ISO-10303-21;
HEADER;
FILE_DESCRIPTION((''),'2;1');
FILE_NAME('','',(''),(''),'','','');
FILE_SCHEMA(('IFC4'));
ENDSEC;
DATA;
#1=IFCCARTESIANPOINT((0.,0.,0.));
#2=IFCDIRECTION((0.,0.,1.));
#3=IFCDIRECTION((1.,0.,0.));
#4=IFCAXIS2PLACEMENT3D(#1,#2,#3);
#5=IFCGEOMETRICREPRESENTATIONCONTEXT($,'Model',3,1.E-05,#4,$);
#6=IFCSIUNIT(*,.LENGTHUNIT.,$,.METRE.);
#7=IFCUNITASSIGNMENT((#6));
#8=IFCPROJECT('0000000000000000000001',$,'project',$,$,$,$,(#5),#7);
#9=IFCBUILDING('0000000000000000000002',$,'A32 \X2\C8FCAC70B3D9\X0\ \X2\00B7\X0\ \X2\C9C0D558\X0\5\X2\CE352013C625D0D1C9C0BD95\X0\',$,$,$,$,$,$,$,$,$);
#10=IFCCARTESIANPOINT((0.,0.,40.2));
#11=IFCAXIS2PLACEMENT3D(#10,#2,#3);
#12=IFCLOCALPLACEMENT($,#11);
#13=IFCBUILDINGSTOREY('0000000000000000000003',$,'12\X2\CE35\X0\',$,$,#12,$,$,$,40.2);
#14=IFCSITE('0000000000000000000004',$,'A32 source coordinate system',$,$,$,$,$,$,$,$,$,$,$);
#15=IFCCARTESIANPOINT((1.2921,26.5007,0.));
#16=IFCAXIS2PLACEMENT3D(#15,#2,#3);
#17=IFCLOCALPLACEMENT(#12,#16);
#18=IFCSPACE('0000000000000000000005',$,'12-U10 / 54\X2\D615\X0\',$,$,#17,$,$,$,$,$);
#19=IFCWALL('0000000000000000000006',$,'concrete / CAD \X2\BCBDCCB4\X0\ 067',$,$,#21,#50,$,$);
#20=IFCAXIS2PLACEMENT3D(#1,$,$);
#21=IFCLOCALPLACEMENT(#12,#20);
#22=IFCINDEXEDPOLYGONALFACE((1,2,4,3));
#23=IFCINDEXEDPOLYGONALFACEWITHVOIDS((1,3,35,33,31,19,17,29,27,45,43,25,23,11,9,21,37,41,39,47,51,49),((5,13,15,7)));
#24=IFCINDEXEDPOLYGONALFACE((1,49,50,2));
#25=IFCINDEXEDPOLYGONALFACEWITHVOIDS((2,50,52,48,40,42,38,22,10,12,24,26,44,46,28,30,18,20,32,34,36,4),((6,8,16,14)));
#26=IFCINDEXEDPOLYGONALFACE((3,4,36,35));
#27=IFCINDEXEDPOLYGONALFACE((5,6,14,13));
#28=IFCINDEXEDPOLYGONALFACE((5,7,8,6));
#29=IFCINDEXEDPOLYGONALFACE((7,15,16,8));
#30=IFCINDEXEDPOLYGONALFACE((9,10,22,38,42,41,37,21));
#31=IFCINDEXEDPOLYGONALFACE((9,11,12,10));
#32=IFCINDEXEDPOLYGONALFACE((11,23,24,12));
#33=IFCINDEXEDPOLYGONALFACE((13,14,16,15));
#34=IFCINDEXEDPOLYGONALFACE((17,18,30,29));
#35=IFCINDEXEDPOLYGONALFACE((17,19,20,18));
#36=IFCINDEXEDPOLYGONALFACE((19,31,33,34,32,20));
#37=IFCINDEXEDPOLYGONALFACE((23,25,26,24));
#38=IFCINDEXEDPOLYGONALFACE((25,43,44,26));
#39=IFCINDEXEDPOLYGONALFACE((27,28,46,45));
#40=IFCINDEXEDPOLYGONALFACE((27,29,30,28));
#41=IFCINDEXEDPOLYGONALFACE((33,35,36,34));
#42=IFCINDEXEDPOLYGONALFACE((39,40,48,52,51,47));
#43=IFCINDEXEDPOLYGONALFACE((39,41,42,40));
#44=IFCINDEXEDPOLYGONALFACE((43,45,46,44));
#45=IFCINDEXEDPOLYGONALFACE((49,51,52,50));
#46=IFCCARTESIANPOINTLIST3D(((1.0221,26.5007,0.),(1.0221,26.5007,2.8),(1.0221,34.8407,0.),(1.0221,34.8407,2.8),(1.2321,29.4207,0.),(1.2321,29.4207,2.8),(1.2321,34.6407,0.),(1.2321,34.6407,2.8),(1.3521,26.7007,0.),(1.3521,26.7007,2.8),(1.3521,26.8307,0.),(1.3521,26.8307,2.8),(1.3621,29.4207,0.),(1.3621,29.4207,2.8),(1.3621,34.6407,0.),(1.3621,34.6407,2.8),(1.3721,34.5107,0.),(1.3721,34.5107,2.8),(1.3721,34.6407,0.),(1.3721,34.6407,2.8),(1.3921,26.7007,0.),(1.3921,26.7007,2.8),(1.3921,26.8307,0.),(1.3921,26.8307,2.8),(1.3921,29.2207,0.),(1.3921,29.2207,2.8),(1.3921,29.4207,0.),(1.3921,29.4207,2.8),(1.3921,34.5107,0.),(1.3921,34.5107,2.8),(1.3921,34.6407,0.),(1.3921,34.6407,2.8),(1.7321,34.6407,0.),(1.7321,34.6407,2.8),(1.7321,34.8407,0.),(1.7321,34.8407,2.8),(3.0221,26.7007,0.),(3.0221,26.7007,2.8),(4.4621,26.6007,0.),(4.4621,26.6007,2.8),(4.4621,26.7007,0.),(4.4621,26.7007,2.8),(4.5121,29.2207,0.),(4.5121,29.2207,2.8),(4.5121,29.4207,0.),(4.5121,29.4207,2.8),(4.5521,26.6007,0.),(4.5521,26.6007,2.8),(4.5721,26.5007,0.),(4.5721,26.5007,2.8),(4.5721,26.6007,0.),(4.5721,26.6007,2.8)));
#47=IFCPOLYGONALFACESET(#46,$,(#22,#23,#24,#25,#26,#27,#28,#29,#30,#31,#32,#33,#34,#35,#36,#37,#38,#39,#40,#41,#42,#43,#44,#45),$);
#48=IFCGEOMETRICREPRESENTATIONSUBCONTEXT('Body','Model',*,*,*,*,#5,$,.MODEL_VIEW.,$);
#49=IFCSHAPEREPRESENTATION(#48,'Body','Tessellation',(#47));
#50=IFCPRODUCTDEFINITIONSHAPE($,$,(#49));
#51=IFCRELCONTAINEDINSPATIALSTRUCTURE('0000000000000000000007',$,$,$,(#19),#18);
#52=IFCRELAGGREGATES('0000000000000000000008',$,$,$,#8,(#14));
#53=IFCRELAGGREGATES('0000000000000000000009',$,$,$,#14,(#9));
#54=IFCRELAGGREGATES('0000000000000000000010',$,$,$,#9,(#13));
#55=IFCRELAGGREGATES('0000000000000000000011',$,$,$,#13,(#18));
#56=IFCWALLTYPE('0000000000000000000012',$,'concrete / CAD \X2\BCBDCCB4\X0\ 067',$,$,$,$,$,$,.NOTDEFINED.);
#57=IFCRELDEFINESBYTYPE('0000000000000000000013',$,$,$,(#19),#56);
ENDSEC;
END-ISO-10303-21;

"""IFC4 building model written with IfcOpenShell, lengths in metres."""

from ifc_helpers import new_model, si_unit, frame, origin, origin_with_axes, place, context, subcontext, project, spatial, polyline, outline, extrude, source, transform, mapped, type_object, type_shapes, element, save


model = new_model("IFC4")

# Units and contexts
model_context = context("Model", 3, precision=1e-05, world=origin_with_axes())
body_context = subcontext(model_context, "Body", "Model", "MODEL_VIEW")
ifc_project = project(units=[si_unit("LENGTHUNIT", "METRE")], contexts=[model_context])

# Site, building, storey, space
site = spatial("IfcSite", under=ifc_project, Name="A32 source coordinate system")
building = spatial("IfcBuilding", under=site, Name="A32 주거동 · 지하5층–옥탑지붕")
storey_placement = place(None, frame((0.0, 0.0, 40.2), z_axis=(0.0, 0.0, 1.0), x_axis=(1.0, 0.0, 0.0)))
storey = spatial("IfcBuildingStorey", under=building, at=storey_placement, Name="12층", Elevation=40.2)
space_placement = place(storey_placement, frame((1.2921, 26.5007, 0.0), z_axis=(0.0, 0.0, 1.0), x_axis=(1.0, 0.0, 0.0)))
space = spatial("IfcSpace", under=storey, at=space_placement, Name="12-U10 / 54형")

# Wall
wall_type_1 = type_object("IfcWallType", Name="concrete / CAD 벽체 067", PredefinedType="NOTDEFINED")
shared_shape_1 = source(origin(), body_context, "Body", "SweptSolid", [
    extrude(outline(polyline([(0.1, 0.2), (1.73, 0.2), (3.17, 0.2), (3.17, 0.1), (3.26, 0.1), (3.28, 0.1), (3.28, 0.0), (-0.27, 0.0), (-0.27, 8.34), (0.44, 8.34), (0.44, 8.14), (0.1, 8.14), (0.08, 8.14), (0.08, 8.01), (0.1, 8.01), (0.1, 2.92), (3.22, 2.92), (3.22, 2.72), (0.1, 2.72), (0.1, 0.33), (0.06, 0.33), (0.06, 0.2), (0.1, 0.2)]), holes=[polyline([(-0.06, 8.14), (-0.06, 2.92), (0.07, 2.92), (0.07, 8.14), (-0.06, 8.14)])]), origin(), (0.0, 0.0, 1.0), 2.8),
])
type_shapes(wall_type_1, [shared_shape_1])
wall_1_placement = place(space_placement, origin_with_axes())
element("IfcWall", 1, at=wall_1_placement, inside=space, type_object=wall_type_1, Name="concrete / CAD 벽체 067", context=body_context, shape_type="MappedRepresentation", body=[
    mapped(shared_shape_1, transform((0.0, 0.0, 0.0), scale=1.0)),
])

save(model, "model.ifc")
